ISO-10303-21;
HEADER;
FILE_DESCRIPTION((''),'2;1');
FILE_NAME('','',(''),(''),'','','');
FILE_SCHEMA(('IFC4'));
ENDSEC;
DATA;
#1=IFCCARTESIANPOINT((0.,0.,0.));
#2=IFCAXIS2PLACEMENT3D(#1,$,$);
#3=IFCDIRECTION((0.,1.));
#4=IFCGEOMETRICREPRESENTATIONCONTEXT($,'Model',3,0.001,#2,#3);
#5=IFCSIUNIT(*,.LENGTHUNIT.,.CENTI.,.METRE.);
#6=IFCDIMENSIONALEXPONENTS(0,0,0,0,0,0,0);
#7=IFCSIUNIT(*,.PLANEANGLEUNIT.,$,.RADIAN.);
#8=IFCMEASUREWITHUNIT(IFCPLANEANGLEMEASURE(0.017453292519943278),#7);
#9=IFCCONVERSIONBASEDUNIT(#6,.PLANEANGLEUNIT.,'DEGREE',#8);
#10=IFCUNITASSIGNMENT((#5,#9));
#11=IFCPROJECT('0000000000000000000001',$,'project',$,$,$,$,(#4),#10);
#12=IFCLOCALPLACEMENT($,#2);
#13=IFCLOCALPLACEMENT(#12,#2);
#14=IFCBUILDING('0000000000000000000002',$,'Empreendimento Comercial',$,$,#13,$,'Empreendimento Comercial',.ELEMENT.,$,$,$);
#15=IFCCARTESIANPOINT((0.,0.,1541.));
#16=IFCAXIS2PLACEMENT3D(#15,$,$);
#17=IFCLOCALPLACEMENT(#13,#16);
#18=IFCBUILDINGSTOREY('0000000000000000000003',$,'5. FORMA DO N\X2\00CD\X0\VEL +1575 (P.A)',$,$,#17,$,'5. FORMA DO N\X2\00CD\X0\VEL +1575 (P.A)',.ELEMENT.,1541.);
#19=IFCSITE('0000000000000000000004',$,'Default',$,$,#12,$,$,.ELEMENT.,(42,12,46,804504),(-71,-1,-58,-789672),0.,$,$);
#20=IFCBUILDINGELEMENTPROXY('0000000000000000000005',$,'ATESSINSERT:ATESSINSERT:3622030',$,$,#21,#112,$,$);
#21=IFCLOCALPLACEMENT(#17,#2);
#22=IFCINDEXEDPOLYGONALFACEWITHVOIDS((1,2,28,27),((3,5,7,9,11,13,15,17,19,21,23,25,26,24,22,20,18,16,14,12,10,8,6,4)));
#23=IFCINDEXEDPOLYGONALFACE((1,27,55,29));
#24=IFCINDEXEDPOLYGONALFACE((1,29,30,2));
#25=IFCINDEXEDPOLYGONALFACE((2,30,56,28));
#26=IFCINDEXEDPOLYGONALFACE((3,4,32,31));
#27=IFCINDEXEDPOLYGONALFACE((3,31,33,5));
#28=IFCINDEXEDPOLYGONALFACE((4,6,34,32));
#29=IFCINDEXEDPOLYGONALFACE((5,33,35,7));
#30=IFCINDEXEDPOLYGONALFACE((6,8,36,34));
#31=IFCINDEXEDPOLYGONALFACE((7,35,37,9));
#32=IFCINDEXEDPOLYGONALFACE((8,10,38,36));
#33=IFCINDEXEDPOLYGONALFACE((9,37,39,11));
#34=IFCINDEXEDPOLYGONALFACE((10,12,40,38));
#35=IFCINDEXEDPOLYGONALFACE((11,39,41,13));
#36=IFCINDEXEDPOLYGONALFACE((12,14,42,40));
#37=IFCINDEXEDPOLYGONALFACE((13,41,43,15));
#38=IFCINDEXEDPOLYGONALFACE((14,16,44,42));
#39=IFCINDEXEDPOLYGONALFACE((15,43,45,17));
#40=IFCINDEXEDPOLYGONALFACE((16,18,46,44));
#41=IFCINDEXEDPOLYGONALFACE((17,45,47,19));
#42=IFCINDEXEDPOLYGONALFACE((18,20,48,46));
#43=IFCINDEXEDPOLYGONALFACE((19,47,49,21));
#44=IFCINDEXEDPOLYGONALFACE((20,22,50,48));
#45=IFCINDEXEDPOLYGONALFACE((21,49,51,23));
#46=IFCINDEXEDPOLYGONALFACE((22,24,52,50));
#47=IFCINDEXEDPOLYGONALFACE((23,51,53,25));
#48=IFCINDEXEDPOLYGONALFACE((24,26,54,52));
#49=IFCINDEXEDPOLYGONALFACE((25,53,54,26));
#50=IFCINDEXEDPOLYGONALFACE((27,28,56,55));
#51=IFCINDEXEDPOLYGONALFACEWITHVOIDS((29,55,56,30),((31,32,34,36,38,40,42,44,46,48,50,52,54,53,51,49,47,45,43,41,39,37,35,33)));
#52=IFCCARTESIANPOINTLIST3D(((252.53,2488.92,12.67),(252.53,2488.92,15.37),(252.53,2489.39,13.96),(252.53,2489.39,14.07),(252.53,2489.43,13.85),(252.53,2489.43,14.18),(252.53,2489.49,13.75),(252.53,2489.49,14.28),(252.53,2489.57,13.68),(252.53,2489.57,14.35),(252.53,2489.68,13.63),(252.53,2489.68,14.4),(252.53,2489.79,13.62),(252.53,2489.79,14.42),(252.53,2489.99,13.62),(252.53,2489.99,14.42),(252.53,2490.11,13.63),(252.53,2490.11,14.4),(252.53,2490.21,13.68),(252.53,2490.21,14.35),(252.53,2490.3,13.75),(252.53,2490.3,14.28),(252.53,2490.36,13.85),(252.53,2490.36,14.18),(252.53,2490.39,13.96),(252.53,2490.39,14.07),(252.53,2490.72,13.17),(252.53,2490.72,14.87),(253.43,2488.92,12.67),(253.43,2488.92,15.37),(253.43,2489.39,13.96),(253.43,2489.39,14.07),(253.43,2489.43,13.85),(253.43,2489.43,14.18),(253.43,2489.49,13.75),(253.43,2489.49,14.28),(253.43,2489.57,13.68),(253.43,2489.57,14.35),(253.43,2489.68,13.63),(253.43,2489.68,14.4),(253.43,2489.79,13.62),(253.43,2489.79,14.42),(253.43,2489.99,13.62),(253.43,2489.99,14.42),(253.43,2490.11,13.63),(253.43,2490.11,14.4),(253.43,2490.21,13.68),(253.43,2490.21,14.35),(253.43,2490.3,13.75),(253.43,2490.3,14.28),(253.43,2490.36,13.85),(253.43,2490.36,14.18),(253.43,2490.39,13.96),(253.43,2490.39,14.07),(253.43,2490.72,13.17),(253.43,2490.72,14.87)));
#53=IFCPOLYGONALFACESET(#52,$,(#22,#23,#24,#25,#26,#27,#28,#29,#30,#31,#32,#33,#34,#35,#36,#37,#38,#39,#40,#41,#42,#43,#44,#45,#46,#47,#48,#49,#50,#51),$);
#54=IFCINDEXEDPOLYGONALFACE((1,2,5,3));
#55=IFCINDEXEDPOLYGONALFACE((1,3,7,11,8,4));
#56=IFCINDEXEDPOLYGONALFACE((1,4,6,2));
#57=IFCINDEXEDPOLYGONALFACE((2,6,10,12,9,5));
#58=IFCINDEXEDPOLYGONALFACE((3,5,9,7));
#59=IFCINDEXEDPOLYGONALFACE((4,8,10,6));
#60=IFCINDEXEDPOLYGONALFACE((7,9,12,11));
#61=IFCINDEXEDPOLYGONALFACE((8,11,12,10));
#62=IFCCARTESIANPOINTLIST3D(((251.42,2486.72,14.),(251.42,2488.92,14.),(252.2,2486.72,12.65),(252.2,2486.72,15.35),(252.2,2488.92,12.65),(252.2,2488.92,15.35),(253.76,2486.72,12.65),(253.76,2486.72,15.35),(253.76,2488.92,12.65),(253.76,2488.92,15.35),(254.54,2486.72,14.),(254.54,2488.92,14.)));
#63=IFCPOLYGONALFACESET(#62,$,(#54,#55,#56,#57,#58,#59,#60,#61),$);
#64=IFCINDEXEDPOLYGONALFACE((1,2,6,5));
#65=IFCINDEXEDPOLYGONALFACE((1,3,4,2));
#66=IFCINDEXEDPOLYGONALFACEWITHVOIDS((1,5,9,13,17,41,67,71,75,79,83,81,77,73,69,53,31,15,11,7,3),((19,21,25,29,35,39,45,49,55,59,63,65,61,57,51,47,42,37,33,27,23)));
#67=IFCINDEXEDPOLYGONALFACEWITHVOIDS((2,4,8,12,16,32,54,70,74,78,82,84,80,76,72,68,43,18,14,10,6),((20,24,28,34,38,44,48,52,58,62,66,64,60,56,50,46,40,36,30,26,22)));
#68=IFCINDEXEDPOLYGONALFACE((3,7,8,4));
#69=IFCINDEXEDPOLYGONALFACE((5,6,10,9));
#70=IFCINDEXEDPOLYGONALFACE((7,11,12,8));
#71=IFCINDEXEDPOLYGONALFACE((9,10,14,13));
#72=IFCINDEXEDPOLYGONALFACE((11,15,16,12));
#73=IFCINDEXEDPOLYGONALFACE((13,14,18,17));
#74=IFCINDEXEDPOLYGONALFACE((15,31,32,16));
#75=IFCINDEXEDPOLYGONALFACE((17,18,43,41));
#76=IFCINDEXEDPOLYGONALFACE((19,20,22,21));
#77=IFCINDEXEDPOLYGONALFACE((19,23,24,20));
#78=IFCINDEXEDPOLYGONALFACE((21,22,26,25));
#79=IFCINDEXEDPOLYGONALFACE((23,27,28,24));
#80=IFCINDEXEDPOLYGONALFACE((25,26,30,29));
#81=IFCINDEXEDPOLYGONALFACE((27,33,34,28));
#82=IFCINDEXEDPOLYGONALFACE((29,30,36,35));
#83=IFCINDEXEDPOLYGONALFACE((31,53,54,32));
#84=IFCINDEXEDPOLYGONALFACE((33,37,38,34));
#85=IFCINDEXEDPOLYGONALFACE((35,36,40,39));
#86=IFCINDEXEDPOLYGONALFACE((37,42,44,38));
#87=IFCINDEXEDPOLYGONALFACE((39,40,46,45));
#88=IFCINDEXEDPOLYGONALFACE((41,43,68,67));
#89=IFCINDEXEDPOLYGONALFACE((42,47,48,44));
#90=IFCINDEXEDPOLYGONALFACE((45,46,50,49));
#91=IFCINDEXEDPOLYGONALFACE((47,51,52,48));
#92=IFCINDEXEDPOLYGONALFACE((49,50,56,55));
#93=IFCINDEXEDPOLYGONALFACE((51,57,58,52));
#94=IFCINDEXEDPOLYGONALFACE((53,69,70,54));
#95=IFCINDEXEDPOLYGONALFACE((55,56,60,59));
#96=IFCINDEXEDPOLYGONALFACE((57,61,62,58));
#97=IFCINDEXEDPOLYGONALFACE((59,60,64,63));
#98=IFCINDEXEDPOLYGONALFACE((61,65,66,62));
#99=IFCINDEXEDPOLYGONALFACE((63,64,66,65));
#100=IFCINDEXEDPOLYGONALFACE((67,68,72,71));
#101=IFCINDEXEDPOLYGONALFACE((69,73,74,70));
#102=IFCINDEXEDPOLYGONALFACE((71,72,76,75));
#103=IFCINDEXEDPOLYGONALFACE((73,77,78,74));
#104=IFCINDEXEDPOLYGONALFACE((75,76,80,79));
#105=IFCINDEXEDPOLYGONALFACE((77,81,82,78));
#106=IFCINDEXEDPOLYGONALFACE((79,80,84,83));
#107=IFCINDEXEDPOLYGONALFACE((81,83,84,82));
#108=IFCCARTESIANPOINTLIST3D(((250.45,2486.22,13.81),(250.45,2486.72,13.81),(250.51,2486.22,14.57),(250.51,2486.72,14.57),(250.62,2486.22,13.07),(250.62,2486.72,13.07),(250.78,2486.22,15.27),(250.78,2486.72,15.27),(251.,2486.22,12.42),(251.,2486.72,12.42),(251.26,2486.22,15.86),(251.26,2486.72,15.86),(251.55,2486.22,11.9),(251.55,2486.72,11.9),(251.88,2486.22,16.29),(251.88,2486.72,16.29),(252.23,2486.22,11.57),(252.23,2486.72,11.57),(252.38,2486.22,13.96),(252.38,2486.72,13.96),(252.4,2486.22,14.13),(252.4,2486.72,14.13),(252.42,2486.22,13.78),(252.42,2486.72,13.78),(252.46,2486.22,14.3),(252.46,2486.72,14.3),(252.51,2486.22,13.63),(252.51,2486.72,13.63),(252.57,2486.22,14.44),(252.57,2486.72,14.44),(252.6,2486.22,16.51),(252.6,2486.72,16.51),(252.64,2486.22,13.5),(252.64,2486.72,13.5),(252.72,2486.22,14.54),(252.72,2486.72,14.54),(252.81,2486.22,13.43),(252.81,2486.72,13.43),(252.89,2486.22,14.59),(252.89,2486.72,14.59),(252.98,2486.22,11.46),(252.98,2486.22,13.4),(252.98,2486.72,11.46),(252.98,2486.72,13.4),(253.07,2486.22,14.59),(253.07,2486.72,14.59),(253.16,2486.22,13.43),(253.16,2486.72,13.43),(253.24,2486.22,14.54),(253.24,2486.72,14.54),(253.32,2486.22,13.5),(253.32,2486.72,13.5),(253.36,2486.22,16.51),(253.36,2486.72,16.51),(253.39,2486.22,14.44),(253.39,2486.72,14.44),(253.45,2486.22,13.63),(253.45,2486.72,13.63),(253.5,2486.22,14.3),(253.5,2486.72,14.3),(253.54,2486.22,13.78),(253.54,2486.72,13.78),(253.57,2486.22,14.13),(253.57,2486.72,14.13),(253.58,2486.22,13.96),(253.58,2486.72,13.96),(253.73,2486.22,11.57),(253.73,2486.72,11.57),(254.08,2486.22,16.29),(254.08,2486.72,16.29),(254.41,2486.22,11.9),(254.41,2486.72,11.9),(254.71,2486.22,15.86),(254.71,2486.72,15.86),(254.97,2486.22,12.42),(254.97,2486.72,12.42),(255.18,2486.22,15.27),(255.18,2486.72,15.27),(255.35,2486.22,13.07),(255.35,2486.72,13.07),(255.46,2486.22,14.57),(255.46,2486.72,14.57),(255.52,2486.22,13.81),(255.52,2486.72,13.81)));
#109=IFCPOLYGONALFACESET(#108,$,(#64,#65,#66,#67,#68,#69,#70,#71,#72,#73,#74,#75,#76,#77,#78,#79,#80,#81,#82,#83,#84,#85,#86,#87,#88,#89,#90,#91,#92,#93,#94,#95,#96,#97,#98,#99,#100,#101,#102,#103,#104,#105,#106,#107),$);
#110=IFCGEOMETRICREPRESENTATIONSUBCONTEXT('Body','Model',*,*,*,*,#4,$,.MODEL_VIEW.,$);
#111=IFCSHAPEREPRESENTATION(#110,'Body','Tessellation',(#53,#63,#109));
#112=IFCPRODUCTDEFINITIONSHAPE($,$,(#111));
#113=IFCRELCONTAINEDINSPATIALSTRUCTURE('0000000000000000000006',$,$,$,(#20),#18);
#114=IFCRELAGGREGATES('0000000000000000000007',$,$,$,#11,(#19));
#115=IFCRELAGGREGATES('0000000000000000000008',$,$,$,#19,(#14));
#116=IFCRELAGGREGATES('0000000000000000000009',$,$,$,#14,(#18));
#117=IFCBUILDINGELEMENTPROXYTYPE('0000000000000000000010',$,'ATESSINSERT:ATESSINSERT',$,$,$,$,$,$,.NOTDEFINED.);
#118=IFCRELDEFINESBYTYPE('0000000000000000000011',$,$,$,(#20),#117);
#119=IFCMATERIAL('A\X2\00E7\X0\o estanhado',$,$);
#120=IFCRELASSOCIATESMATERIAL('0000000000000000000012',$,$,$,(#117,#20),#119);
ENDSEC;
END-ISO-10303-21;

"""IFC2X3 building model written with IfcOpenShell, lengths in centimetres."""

from ifc_helpers import new_model, entity, si_unit, converted_unit, direction, frame, frame_2d, origin, place, context, subcontext, project, spatial, polyline, circle_curve, parameter, trimmed, segment, composite_curve, hollow_circle, outline, extrude, source, transform, mapped, material, type_object, type_shapes, element, save


model = new_model("IFC2X3")

# Units and contexts
model_context = context("Model", 3, precision=0.001, world=origin(), true_north=direction((0.0, 1.0)))
body_context = subcontext(model_context, "Body", "Model", "MODEL_VIEW")
ifc_project = project(units=[si_unit("LENGTHUNIT", "METRE", prefix="CENTI"), converted_unit("PLANEANGLEUNIT", "DEGREE", entity("IfcPlaneAngleMeasure", 0.017453292519943278), si_unit("PLANEANGLEUNIT", "RADIAN"), dimensions=[0, 0, 0, 0, 0, 0, 0])], contexts=[model_context])

# Site, building, storey
site_placement = place(None, origin())
site = spatial("IfcSite", under=ifc_project, at=site_placement, Name="Default", CompositionType="ELEMENT", RefLatitude=(42, 12, 46, 804504), RefLongitude=(-71, -1, -58, -789672), RefElevation=0.0)
building_placement = place(site_placement, origin())
building = spatial("IfcBuilding", under=site, at=building_placement, Name="Empreendimento Comercial", LongName="Empreendimento Comercial", CompositionType="ELEMENT")
storey_placement = place(building_placement, frame((0.0, 0.0, 1541.0)))
storey = spatial("IfcBuildingStorey", under=building, at=storey_placement, Name="5. FORMA DO NÍVEL +1575 (P.A)", LongName="5. FORMA DO NÍVEL +1575 (P.A)", CompositionType="ELEMENT", Elevation=1541.0)

# Building element proxy
ifc_material_1 = material(Name="Aço estanhado")
building_element_proxy_type_1 = type_object("IfcBuildingElementProxyType", Name="ATESSINSERT:ATESSINSERT", PredefinedType="NOTDEFINED", material=ifc_material_1)
shared_shape_1 = source(origin(), body_context, "Body", "SweptSolid", [
    extrude(outline(polyline([(-1.35, -0.9), (1.35, -0.9), (0.85, 0.9), (-0.85, 0.9), (-1.35, -0.9)]), holes=[composite_curve([segment(trimmed(circle_curve(frame_2d((0.0, 0.17), x_axis=(1.0, 0.0)), 0.4), [parameter(0.0)], [parameter(180.0)], True, "PARAMETER"), False, "CONTINUOUS"), segment(polyline([(0.4, 0.17), (0.4, -0.03)]), True, "CONTINUOUS"), segment(trimmed(circle_curve(frame_2d((0.0, -0.03), x_axis=(1.0, 0.0)), 0.4), [parameter(180.0)], [parameter(0.0)], True, "PARAMETER"), False, "CONTINUOUS"), segment(polyline([(-0.4, -0.03), (-0.4, 0.17)]), True, "CONTINUOUS")], self_intersect=False)]), frame((-1.4, -0.45, 30.02), z_axis=(0.0, 1.0, 0.0), x_axis=(0.0, 0.0, 1.0)), (0.0, 0.0, 1.0), 0.9),
    extrude(outline(polyline([(-0.78, -1.35), (0.78, -1.35), (1.56, 0.0), (0.78, 1.35), (-0.78, 1.35), (-1.56, 0.0), (-0.78, -1.35)])), frame((-4.5, 0.0, 30.0), z_axis=(1.0, 0.0, 0.0), x_axis=(0.0, 0.5, 0.866025)), (0.0, 0.0, 1.0), 2.2),
    extrude(hollow_circle(Radius=2.54, WallThickness=1.94, at=frame_2d((0.0, 0.0), x_axis=(1.0, 0.0))), frame((-5.0, 0.0, 30.0), z_axis=(1.0, 0.0, 0.0), x_axis=(0.0, 0.0, -1.0)), (0.0, 0.0, 1.0), 0.5),
])
type_shapes(building_element_proxy_type_1, [shared_shape_1])
for number, where, z_axis, x_axis, name in (
    (1, (252.98, 2491.22, -16.0), (0.0, 0.0, 1.0), (0.0, 1.0, 0.0), "ATESSINSERT:ATESSINSERT:3622030"),
):
    element("IfcBuildingElementProxy", number, at=place(storey_placement, frame(where, z_axis=z_axis, x_axis=x_axis)), inside=storey, type_object=building_element_proxy_type_1, material=ifc_material_1, Name=name, context=body_context, shape_type="MappedRepresentation", body=[
        mapped(shared_shape_1, transform((0.0, 0.0, 0.0), scale=1.0)),
    ])

save(model, "model.ifc")
